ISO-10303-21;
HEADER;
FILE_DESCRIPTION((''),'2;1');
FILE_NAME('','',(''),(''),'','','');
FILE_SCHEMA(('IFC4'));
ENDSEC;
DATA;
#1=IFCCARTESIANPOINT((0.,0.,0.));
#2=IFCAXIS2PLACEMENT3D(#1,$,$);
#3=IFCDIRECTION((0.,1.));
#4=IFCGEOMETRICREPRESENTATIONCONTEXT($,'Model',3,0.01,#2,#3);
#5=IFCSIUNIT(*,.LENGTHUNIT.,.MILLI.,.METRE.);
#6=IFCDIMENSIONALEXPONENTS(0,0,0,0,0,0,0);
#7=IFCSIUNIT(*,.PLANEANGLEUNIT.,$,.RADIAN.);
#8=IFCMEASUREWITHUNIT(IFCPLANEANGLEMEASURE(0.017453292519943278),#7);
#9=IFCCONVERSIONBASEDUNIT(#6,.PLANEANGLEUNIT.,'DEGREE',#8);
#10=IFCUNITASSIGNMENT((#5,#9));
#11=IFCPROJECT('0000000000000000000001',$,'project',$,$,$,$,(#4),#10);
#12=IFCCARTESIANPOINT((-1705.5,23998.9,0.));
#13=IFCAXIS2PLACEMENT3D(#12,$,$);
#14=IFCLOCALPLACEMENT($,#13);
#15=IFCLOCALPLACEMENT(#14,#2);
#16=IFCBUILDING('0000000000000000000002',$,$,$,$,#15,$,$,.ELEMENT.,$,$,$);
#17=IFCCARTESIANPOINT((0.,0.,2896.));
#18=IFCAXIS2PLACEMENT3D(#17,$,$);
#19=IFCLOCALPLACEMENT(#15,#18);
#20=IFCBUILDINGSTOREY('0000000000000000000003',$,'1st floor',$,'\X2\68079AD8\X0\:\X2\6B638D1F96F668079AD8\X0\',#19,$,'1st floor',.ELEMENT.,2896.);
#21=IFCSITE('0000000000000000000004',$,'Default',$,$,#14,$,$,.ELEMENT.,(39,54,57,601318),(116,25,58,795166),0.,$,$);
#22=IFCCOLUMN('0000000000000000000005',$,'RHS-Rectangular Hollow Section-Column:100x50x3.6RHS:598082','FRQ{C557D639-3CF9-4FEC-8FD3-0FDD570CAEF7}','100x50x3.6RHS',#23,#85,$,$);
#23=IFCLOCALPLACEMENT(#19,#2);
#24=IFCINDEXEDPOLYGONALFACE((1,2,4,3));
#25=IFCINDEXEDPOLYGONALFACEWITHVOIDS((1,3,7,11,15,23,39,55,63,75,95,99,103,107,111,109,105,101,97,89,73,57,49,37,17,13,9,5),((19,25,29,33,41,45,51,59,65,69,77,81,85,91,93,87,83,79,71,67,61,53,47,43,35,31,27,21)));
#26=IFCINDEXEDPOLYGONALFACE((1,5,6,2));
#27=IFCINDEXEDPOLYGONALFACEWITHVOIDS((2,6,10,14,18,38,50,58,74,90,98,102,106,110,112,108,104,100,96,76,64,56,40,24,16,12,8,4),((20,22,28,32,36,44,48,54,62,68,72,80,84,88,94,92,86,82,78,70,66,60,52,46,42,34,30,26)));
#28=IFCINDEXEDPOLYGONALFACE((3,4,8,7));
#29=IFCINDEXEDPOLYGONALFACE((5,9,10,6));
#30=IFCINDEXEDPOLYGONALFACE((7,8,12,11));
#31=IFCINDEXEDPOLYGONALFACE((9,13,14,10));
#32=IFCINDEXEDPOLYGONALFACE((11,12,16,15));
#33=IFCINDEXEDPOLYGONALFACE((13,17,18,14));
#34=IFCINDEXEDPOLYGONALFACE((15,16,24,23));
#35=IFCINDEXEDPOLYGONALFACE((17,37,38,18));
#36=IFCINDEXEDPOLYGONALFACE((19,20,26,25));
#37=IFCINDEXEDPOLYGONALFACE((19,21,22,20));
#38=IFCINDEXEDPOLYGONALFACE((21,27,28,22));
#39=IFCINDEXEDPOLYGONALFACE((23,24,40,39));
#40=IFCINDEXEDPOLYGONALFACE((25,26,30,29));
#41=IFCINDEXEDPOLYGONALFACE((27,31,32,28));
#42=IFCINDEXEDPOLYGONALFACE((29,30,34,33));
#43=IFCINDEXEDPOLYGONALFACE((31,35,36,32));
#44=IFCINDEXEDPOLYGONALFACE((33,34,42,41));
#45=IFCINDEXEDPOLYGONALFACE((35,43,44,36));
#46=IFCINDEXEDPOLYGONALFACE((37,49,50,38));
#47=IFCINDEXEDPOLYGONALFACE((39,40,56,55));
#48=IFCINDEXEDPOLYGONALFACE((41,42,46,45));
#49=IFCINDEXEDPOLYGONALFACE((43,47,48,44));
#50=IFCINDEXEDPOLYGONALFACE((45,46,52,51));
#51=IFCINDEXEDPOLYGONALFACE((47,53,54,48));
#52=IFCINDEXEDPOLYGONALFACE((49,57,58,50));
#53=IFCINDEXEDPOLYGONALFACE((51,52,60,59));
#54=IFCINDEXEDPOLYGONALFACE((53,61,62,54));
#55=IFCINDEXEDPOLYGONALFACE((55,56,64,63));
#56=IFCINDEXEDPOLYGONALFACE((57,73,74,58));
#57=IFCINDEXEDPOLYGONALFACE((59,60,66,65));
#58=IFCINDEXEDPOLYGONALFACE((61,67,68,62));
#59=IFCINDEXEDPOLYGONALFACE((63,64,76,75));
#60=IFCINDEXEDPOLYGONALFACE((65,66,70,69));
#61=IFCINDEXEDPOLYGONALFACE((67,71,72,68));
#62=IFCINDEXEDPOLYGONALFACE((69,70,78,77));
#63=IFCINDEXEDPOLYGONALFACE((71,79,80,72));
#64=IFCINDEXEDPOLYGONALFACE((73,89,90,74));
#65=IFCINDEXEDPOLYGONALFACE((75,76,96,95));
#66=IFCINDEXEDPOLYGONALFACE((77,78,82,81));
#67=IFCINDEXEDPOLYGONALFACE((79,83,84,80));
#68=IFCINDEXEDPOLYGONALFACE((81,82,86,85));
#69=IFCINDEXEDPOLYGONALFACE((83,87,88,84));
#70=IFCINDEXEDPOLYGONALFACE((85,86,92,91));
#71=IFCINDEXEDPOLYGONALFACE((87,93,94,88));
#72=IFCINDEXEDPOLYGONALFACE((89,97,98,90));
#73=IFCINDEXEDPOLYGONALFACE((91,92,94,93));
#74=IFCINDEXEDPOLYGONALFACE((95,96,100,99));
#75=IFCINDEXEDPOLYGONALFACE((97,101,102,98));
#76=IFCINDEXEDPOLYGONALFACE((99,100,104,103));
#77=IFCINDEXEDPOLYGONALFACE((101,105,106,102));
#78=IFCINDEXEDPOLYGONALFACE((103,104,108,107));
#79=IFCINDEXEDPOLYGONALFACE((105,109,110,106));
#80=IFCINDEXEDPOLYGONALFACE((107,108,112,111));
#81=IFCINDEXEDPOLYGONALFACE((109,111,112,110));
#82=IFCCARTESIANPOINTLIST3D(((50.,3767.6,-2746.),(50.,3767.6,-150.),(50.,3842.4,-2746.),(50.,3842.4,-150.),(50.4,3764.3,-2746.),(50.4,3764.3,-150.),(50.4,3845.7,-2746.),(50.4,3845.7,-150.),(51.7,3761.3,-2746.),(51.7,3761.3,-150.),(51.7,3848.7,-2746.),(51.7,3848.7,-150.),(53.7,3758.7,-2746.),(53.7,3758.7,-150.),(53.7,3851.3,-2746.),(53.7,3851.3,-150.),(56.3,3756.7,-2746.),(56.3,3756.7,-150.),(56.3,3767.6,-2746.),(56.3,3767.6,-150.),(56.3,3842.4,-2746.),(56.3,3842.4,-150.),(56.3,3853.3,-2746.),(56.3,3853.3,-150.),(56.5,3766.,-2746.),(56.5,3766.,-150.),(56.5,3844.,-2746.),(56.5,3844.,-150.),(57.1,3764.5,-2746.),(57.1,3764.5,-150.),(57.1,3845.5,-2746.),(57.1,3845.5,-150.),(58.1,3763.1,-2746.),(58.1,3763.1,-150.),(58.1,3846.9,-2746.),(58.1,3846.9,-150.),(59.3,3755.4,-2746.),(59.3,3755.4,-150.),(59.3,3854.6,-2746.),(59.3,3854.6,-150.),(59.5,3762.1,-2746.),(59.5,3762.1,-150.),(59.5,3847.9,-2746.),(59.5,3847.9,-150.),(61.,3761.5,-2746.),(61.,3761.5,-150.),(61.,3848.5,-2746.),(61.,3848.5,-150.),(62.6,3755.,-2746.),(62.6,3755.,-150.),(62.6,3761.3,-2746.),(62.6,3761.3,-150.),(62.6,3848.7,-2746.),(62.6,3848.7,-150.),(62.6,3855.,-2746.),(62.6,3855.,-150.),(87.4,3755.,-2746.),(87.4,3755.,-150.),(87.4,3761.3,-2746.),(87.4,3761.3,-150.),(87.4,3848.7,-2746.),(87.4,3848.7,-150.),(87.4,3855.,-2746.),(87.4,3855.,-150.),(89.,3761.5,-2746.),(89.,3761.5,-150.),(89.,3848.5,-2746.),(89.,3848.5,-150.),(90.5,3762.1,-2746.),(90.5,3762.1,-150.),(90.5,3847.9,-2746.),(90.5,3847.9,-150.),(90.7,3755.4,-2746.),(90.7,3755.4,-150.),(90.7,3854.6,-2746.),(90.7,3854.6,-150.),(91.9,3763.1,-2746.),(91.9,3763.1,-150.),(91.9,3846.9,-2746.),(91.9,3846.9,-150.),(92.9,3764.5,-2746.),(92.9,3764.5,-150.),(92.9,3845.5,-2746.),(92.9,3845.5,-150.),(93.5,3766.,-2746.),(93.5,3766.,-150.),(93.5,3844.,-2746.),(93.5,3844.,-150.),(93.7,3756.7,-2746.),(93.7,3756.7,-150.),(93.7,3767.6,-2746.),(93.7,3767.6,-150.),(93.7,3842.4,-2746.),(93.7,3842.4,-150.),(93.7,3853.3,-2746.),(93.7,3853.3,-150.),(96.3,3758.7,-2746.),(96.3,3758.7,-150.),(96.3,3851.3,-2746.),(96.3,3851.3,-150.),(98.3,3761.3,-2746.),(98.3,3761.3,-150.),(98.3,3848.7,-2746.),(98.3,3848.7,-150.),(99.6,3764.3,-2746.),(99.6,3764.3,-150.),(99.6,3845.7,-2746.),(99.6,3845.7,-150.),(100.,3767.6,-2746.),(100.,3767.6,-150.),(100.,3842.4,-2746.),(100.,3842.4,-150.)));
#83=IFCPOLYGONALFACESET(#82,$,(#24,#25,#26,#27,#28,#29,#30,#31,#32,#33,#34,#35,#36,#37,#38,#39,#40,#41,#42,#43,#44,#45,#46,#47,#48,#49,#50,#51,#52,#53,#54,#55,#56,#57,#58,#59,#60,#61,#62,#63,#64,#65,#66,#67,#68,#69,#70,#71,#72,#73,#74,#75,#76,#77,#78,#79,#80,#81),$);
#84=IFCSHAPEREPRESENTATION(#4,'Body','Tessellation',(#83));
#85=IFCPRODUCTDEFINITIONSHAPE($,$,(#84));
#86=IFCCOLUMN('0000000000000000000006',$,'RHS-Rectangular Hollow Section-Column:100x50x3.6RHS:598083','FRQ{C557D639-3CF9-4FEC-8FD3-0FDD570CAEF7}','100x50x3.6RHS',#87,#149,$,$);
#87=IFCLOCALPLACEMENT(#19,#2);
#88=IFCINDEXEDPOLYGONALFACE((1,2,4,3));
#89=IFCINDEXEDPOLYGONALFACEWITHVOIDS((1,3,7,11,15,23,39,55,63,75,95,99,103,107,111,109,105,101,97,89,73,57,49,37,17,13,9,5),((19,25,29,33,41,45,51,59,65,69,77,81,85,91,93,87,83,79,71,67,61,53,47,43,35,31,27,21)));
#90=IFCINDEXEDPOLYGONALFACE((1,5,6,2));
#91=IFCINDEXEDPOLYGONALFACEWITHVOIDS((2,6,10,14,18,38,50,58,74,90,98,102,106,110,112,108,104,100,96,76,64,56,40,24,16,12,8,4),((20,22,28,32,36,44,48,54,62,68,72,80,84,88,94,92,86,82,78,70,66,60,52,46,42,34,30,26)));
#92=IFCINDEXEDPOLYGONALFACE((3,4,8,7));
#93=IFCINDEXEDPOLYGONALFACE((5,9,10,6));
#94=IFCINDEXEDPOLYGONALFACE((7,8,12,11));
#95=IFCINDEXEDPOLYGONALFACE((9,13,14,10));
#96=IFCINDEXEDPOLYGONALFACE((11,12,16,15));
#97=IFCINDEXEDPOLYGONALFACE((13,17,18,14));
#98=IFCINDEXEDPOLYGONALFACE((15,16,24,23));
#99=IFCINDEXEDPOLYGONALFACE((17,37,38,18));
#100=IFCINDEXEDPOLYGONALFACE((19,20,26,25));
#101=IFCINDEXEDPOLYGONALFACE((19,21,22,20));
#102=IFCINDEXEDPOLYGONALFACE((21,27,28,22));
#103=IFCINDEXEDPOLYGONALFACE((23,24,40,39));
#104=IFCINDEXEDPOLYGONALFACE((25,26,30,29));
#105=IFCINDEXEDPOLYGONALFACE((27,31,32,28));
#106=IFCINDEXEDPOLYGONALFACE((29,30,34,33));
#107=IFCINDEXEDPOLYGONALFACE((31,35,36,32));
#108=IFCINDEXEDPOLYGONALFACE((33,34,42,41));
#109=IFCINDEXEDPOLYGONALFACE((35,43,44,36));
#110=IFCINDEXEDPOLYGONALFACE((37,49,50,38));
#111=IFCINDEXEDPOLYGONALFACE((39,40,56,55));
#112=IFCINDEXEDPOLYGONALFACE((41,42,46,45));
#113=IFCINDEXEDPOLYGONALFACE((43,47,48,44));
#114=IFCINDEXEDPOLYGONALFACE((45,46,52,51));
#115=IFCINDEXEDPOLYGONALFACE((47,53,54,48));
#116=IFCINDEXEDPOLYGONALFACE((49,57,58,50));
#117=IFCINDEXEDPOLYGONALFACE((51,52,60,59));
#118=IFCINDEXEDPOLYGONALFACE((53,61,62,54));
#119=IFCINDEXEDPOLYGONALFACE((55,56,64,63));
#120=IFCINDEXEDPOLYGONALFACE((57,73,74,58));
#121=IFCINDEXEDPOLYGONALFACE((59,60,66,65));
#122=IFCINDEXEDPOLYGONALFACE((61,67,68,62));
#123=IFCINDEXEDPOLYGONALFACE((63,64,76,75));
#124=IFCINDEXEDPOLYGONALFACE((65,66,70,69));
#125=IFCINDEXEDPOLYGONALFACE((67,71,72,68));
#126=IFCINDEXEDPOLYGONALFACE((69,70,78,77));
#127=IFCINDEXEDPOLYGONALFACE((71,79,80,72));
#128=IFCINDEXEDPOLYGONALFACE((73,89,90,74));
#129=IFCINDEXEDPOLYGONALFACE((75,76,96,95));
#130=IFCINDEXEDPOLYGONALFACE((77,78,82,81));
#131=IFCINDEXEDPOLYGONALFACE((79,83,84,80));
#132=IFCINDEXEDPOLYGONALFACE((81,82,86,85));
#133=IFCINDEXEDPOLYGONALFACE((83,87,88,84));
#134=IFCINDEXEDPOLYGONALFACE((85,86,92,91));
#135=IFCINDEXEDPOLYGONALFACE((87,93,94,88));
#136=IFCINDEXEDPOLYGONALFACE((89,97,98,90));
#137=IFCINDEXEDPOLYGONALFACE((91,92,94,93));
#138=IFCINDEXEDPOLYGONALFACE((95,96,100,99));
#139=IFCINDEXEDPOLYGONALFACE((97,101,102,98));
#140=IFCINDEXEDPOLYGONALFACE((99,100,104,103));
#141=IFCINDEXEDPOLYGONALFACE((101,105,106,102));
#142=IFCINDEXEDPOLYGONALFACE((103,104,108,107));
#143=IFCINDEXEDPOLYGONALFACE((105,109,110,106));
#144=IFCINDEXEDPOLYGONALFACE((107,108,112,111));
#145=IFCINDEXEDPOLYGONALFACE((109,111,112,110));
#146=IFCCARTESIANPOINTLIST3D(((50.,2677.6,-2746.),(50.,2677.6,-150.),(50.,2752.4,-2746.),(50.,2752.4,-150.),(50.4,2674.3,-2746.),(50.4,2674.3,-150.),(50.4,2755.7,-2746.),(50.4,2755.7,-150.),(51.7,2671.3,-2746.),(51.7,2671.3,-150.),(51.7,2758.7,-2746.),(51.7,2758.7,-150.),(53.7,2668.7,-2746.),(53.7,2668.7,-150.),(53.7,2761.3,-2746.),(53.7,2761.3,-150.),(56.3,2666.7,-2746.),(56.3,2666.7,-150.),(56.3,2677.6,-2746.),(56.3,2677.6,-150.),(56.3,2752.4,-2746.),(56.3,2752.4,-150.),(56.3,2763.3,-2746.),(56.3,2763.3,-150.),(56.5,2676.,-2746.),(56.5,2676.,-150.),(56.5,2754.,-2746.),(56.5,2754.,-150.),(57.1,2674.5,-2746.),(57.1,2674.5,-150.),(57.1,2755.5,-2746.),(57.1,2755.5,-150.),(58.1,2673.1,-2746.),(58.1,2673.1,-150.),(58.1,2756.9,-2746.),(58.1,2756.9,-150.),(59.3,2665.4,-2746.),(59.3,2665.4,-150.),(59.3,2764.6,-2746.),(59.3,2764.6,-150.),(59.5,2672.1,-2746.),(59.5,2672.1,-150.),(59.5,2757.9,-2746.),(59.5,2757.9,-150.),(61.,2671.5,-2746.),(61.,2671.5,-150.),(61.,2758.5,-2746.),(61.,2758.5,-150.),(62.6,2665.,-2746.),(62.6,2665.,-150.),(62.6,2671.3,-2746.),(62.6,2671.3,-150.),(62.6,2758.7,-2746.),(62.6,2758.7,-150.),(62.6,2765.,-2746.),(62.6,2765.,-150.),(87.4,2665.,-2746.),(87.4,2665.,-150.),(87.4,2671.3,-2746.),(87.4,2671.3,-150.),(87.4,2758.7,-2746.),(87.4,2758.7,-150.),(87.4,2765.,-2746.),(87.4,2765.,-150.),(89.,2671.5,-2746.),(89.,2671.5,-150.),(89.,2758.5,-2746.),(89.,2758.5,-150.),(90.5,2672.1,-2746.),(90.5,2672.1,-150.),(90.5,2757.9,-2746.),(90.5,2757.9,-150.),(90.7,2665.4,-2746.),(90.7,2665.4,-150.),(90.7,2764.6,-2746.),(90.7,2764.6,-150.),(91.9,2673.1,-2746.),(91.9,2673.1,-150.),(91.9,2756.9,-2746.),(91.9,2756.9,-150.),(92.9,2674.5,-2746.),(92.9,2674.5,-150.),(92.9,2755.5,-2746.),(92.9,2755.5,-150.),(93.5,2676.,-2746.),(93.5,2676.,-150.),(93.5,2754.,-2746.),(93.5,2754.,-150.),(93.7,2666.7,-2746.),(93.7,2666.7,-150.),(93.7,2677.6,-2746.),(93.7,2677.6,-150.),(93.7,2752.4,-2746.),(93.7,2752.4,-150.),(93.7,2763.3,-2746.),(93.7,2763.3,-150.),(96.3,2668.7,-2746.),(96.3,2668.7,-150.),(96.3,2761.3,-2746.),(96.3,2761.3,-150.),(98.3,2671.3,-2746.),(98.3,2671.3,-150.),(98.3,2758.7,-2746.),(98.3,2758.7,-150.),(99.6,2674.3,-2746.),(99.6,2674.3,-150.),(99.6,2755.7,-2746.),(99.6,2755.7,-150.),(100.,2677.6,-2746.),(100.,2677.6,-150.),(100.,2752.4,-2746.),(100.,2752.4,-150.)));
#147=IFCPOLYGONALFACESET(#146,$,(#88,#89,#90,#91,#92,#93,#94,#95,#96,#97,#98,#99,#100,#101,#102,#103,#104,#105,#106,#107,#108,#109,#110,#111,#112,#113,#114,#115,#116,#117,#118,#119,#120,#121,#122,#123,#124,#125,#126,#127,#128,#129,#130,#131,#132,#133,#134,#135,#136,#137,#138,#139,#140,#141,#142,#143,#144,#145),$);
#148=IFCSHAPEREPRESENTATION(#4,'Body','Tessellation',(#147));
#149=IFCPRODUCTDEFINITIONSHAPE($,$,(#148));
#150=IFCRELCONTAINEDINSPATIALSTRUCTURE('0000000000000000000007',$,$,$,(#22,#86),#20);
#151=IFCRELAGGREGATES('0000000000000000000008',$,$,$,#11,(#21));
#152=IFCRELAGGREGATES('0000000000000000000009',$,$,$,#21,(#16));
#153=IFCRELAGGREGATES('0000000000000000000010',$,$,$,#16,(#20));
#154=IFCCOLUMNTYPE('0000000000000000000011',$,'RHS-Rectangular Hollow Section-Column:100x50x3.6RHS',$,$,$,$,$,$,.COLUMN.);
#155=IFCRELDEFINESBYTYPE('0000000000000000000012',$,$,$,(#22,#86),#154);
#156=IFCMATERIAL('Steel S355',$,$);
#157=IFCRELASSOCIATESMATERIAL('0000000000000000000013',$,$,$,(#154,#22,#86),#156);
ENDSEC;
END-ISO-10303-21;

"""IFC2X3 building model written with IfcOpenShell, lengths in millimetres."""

from ifc_helpers import new_model, entity, si_unit, converted_unit, point, direction, frame, frame_2d, origin, origin_2d, place, context, project, spatial, circle_curve, line_curve, trimmed, segment, composite_curve, hollow_rectangle, outline, extrude, clip, halfspace, material, type_object, element, save


model = new_model("IFC2X3")

# Units and contexts
model_context = context("Model", 3, precision=0.01, world=origin(), true_north=direction((0.0, 1.0)))
ifc_project = project(units=[si_unit("LENGTHUNIT", "METRE", prefix="MILLI"), converted_unit("PLANEANGLEUNIT", "DEGREE", entity("IfcPlaneAngleMeasure", 0.017453292519943278), si_unit("PLANEANGLEUNIT", "RADIAN"), dimensions=[0, 0, 0, 0, 0, 0, 0])], contexts=[model_context])

# Site, building, storey
site_placement = place(None, frame((-1705.5, 23998.9, 0.0)))
site = spatial("IfcSite", under=ifc_project, at=site_placement, Name="Default", CompositionType="ELEMENT", RefLatitude=(39, 54, 57, 601318), RefLongitude=(116, 25, 58, 795166), RefElevation=0.0)
building_placement = place(site_placement, origin())
building = spatial("IfcBuilding", under=site, at=building_placement, CompositionType="ELEMENT")
storey_placement = place(building_placement, frame((0.0, 0.0, 2896.0)))
storey = spatial("IfcBuildingStorey", under=building, at=storey_placement, Name="1st floor", ObjectType="标高:正负零标高", LongName="1st floor", CompositionType="ELEMENT", Elevation=2896.0)

# Columns, openings
ifc_material_1 = material(Name="Steel S355")
column_type_1 = type_object("IfcColumnType", Name="RHS-Rectangular Hollow Section-Column:100x50x3.6RHS", PredefinedType="COLUMN", material=ifc_material_1)
column_1_placement = place(storey_placement, frame((75.0, 3805.0, -19.1)))
column_1 = element("IfcColumn", 1, at=column_1_placement, inside=storey, type_object=column_type_1, material=ifc_material_1, Name="RHS-Rectangular Hollow Section-Column:100x50x3.6RHS:598082", Description="FRQ{C557D639-3CF9-4FEC-8FD3-0FDD570CAEF7}", ObjectType="100x50x3.6RHS", context=model_context, shape_type="Clipping", body=[
    clip(clip(extrude(hollow_rectangle(XDim=50.0, YDim=100.0, WallThickness=6.3, InnerFilletRadius=6.3, OuterFilletRadius=12.6, at=origin_2d()), origin(), (0.0, 0.0, -1.0), 2782.8), halfspace(frame((-75.0, -3805.0, -55.9), z_axis=(0.0, 0.0, -1.0), x_axis=(-1.0, 0.0, 0.0)), True)), halfspace(frame((-75.0, -3805.0, -2726.9), z_axis=(0.0, 0.0, 1.0), x_axis=(1.0, 0.0, 0.0)), True)),
])
opening_1_placement = place(column_1_placement, frame((0.0, -150.1, -130.9), z_axis=(0.0, 1.0, 0.0), x_axis=(-1.0, 0.0, 0.0)))
element("IfcOpeningElement", 2, at=opening_1_placement, cuts=column_1, ObjectType="Opening", context=model_context, shape_type="SweptSolid", body=[
    extrude(outline(composite_curve([segment(trimmed(circle_curve(frame_2d((43.0, 32.0), x_axis=(1.0, 0.0)), 32.0), [point((43.0, 0.0))], [point((75.0, 32.0))], True, "CARTESIAN"), True, "CONTINUOUS"), segment(trimmed(line_curve((75.0, 32.0), (0.0, 1.0), 86.0), [point((75.0, 32.0))], [point((75.0, 118.0))], True, "CARTESIAN"), True, "CONTINUOUS"), segment(trimmed(circle_curve(frame_2d((43.0, 118.0), x_axis=(1.0, 0.0)), 32.0), [point((75.0, 118.0))], [point((43.0, 150.0))], True, "CARTESIAN"), True, "CONTINUOUS"), segment(trimmed(line_curve((43.0, 150.0), (-1.0, 0.0), 86.0), [point((43.0, 150.0))], [point((-43.0, 150.0))], True, "CARTESIAN"), True, "CONTINUOUS"), segment(trimmed(circle_curve(frame_2d((-43.0, 118.0), x_axis=(1.0, 0.0)), 32.0), [point((-43.0, 150.0))], [point((-75.0, 118.0))], True, "CARTESIAN"), True, "CONTINUOUS"), segment(trimmed(line_curve((-75.0, 118.0), (0.0, -1.0), 86.0), [point((-75.0, 118.0))], [point((-75.0, 32.0))], True, "CARTESIAN"), True, "CONTINUOUS"), segment(trimmed(circle_curve(frame_2d((-43.0, 32.0), x_axis=(1.0, 0.0)), 32.0), [point((-75.0, 32.0))], [point((-43.0, 0.0))], True, "CARTESIAN"), True, "CONTINUOUS"), segment(trimmed(line_curve((-43.0, 0.0), (1.0, 0.0), 86.0), [point((-43.0, 0.0))], [point((43.0, 0.0))], True, "CARTESIAN"), True, "CONTINUOUS")], self_intersect="UNKNOWN")), origin(), (0.0, 0.0, 1.0), 300.2),
])
column_2_placement = place(storey_placement, frame((75.0, 2715.0, -19.1)))
column_2 = element("IfcColumn", 3, at=column_2_placement, inside=storey, type_object=column_type_1, material=ifc_material_1, Name="RHS-Rectangular Hollow Section-Column:100x50x3.6RHS:598083", Description="FRQ{C557D639-3CF9-4FEC-8FD3-0FDD570CAEF7}", ObjectType="100x50x3.6RHS", context=model_context, shape_type="Clipping", body=[
    clip(clip(extrude(hollow_rectangle(XDim=50.0, YDim=100.0, WallThickness=6.3, InnerFilletRadius=6.3, OuterFilletRadius=12.6, at=origin_2d()), origin(), (0.0, 0.0, -1.0), 2782.8), halfspace(frame((-75.0, -2715.0, -55.9), z_axis=(0.0, 0.0, -1.0), x_axis=(-1.0, 0.0, 0.0)), True)), halfspace(frame((-75.0, -2715.0, -2726.9), z_axis=(0.0, 0.0, 1.0), x_axis=(1.0, 0.0, 0.0)), True)),
])
opening_2_placement = place(column_2_placement, frame((0.0, -150.1, -130.9), z_axis=(0.0, 1.0, 0.0), x_axis=(-1.0, 0.0, 0.0)))
element("IfcOpeningElement", 4, at=opening_2_placement, cuts=column_2, ObjectType="Opening", context=model_context, shape_type="SweptSolid", body=[
    extrude(outline(composite_curve([segment(trimmed(circle_curve(frame_2d((43.0, 32.0), x_axis=(1.0, 0.0)), 32.0), [point((43.0, 0.0))], [point((75.0, 32.0))], True, "CARTESIAN"), True, "CONTINUOUS"), segment(trimmed(line_curve((75.0, 32.0), (0.0, 1.0), 86.0), [point((75.0, 32.0))], [point((75.0, 118.0))], True, "CARTESIAN"), True, "CONTINUOUS"), segment(trimmed(circle_curve(frame_2d((43.0, 118.0), x_axis=(1.0, 0.0)), 32.0), [point((75.0, 118.0))], [point((43.0, 150.0))], True, "CARTESIAN"), True, "CONTINUOUS"), segment(trimmed(line_curve((43.0, 150.0), (-1.0, 0.0), 86.0), [point((43.0, 150.0))], [point((-43.0, 150.0))], True, "CARTESIAN"), True, "CONTINUOUS"), segment(trimmed(circle_curve(frame_2d((-43.0, 118.0), x_axis=(1.0, 0.0)), 32.0), [point((-43.0, 150.0))], [point((-75.0, 118.0))], True, "CARTESIAN"), True, "CONTINUOUS"), segment(trimmed(line_curve((-75.0, 118.0), (0.0, -1.0), 86.0), [point((-75.0, 118.0))], [point((-75.0, 32.0))], True, "CARTESIAN"), True, "CONTINUOUS"), segment(trimmed(circle_curve(frame_2d((-43.0, 32.0), x_axis=(1.0, 0.0)), 32.0), [point((-75.0, 32.0))], [point((-43.0, 0.0))], True, "CARTESIAN"), True, "CONTINUOUS"), segment(trimmed(line_curve((-43.0, 0.0), (1.0, 0.0), 86.0), [point((-43.0, 0.0))], [point((43.0, 0.0))], True, "CARTESIAN"), True, "CONTINUOUS")], self_intersect="UNKNOWN")), origin(), (0.0, 0.0, 1.0), 300.2),
])

save(model, "model.ifc")
